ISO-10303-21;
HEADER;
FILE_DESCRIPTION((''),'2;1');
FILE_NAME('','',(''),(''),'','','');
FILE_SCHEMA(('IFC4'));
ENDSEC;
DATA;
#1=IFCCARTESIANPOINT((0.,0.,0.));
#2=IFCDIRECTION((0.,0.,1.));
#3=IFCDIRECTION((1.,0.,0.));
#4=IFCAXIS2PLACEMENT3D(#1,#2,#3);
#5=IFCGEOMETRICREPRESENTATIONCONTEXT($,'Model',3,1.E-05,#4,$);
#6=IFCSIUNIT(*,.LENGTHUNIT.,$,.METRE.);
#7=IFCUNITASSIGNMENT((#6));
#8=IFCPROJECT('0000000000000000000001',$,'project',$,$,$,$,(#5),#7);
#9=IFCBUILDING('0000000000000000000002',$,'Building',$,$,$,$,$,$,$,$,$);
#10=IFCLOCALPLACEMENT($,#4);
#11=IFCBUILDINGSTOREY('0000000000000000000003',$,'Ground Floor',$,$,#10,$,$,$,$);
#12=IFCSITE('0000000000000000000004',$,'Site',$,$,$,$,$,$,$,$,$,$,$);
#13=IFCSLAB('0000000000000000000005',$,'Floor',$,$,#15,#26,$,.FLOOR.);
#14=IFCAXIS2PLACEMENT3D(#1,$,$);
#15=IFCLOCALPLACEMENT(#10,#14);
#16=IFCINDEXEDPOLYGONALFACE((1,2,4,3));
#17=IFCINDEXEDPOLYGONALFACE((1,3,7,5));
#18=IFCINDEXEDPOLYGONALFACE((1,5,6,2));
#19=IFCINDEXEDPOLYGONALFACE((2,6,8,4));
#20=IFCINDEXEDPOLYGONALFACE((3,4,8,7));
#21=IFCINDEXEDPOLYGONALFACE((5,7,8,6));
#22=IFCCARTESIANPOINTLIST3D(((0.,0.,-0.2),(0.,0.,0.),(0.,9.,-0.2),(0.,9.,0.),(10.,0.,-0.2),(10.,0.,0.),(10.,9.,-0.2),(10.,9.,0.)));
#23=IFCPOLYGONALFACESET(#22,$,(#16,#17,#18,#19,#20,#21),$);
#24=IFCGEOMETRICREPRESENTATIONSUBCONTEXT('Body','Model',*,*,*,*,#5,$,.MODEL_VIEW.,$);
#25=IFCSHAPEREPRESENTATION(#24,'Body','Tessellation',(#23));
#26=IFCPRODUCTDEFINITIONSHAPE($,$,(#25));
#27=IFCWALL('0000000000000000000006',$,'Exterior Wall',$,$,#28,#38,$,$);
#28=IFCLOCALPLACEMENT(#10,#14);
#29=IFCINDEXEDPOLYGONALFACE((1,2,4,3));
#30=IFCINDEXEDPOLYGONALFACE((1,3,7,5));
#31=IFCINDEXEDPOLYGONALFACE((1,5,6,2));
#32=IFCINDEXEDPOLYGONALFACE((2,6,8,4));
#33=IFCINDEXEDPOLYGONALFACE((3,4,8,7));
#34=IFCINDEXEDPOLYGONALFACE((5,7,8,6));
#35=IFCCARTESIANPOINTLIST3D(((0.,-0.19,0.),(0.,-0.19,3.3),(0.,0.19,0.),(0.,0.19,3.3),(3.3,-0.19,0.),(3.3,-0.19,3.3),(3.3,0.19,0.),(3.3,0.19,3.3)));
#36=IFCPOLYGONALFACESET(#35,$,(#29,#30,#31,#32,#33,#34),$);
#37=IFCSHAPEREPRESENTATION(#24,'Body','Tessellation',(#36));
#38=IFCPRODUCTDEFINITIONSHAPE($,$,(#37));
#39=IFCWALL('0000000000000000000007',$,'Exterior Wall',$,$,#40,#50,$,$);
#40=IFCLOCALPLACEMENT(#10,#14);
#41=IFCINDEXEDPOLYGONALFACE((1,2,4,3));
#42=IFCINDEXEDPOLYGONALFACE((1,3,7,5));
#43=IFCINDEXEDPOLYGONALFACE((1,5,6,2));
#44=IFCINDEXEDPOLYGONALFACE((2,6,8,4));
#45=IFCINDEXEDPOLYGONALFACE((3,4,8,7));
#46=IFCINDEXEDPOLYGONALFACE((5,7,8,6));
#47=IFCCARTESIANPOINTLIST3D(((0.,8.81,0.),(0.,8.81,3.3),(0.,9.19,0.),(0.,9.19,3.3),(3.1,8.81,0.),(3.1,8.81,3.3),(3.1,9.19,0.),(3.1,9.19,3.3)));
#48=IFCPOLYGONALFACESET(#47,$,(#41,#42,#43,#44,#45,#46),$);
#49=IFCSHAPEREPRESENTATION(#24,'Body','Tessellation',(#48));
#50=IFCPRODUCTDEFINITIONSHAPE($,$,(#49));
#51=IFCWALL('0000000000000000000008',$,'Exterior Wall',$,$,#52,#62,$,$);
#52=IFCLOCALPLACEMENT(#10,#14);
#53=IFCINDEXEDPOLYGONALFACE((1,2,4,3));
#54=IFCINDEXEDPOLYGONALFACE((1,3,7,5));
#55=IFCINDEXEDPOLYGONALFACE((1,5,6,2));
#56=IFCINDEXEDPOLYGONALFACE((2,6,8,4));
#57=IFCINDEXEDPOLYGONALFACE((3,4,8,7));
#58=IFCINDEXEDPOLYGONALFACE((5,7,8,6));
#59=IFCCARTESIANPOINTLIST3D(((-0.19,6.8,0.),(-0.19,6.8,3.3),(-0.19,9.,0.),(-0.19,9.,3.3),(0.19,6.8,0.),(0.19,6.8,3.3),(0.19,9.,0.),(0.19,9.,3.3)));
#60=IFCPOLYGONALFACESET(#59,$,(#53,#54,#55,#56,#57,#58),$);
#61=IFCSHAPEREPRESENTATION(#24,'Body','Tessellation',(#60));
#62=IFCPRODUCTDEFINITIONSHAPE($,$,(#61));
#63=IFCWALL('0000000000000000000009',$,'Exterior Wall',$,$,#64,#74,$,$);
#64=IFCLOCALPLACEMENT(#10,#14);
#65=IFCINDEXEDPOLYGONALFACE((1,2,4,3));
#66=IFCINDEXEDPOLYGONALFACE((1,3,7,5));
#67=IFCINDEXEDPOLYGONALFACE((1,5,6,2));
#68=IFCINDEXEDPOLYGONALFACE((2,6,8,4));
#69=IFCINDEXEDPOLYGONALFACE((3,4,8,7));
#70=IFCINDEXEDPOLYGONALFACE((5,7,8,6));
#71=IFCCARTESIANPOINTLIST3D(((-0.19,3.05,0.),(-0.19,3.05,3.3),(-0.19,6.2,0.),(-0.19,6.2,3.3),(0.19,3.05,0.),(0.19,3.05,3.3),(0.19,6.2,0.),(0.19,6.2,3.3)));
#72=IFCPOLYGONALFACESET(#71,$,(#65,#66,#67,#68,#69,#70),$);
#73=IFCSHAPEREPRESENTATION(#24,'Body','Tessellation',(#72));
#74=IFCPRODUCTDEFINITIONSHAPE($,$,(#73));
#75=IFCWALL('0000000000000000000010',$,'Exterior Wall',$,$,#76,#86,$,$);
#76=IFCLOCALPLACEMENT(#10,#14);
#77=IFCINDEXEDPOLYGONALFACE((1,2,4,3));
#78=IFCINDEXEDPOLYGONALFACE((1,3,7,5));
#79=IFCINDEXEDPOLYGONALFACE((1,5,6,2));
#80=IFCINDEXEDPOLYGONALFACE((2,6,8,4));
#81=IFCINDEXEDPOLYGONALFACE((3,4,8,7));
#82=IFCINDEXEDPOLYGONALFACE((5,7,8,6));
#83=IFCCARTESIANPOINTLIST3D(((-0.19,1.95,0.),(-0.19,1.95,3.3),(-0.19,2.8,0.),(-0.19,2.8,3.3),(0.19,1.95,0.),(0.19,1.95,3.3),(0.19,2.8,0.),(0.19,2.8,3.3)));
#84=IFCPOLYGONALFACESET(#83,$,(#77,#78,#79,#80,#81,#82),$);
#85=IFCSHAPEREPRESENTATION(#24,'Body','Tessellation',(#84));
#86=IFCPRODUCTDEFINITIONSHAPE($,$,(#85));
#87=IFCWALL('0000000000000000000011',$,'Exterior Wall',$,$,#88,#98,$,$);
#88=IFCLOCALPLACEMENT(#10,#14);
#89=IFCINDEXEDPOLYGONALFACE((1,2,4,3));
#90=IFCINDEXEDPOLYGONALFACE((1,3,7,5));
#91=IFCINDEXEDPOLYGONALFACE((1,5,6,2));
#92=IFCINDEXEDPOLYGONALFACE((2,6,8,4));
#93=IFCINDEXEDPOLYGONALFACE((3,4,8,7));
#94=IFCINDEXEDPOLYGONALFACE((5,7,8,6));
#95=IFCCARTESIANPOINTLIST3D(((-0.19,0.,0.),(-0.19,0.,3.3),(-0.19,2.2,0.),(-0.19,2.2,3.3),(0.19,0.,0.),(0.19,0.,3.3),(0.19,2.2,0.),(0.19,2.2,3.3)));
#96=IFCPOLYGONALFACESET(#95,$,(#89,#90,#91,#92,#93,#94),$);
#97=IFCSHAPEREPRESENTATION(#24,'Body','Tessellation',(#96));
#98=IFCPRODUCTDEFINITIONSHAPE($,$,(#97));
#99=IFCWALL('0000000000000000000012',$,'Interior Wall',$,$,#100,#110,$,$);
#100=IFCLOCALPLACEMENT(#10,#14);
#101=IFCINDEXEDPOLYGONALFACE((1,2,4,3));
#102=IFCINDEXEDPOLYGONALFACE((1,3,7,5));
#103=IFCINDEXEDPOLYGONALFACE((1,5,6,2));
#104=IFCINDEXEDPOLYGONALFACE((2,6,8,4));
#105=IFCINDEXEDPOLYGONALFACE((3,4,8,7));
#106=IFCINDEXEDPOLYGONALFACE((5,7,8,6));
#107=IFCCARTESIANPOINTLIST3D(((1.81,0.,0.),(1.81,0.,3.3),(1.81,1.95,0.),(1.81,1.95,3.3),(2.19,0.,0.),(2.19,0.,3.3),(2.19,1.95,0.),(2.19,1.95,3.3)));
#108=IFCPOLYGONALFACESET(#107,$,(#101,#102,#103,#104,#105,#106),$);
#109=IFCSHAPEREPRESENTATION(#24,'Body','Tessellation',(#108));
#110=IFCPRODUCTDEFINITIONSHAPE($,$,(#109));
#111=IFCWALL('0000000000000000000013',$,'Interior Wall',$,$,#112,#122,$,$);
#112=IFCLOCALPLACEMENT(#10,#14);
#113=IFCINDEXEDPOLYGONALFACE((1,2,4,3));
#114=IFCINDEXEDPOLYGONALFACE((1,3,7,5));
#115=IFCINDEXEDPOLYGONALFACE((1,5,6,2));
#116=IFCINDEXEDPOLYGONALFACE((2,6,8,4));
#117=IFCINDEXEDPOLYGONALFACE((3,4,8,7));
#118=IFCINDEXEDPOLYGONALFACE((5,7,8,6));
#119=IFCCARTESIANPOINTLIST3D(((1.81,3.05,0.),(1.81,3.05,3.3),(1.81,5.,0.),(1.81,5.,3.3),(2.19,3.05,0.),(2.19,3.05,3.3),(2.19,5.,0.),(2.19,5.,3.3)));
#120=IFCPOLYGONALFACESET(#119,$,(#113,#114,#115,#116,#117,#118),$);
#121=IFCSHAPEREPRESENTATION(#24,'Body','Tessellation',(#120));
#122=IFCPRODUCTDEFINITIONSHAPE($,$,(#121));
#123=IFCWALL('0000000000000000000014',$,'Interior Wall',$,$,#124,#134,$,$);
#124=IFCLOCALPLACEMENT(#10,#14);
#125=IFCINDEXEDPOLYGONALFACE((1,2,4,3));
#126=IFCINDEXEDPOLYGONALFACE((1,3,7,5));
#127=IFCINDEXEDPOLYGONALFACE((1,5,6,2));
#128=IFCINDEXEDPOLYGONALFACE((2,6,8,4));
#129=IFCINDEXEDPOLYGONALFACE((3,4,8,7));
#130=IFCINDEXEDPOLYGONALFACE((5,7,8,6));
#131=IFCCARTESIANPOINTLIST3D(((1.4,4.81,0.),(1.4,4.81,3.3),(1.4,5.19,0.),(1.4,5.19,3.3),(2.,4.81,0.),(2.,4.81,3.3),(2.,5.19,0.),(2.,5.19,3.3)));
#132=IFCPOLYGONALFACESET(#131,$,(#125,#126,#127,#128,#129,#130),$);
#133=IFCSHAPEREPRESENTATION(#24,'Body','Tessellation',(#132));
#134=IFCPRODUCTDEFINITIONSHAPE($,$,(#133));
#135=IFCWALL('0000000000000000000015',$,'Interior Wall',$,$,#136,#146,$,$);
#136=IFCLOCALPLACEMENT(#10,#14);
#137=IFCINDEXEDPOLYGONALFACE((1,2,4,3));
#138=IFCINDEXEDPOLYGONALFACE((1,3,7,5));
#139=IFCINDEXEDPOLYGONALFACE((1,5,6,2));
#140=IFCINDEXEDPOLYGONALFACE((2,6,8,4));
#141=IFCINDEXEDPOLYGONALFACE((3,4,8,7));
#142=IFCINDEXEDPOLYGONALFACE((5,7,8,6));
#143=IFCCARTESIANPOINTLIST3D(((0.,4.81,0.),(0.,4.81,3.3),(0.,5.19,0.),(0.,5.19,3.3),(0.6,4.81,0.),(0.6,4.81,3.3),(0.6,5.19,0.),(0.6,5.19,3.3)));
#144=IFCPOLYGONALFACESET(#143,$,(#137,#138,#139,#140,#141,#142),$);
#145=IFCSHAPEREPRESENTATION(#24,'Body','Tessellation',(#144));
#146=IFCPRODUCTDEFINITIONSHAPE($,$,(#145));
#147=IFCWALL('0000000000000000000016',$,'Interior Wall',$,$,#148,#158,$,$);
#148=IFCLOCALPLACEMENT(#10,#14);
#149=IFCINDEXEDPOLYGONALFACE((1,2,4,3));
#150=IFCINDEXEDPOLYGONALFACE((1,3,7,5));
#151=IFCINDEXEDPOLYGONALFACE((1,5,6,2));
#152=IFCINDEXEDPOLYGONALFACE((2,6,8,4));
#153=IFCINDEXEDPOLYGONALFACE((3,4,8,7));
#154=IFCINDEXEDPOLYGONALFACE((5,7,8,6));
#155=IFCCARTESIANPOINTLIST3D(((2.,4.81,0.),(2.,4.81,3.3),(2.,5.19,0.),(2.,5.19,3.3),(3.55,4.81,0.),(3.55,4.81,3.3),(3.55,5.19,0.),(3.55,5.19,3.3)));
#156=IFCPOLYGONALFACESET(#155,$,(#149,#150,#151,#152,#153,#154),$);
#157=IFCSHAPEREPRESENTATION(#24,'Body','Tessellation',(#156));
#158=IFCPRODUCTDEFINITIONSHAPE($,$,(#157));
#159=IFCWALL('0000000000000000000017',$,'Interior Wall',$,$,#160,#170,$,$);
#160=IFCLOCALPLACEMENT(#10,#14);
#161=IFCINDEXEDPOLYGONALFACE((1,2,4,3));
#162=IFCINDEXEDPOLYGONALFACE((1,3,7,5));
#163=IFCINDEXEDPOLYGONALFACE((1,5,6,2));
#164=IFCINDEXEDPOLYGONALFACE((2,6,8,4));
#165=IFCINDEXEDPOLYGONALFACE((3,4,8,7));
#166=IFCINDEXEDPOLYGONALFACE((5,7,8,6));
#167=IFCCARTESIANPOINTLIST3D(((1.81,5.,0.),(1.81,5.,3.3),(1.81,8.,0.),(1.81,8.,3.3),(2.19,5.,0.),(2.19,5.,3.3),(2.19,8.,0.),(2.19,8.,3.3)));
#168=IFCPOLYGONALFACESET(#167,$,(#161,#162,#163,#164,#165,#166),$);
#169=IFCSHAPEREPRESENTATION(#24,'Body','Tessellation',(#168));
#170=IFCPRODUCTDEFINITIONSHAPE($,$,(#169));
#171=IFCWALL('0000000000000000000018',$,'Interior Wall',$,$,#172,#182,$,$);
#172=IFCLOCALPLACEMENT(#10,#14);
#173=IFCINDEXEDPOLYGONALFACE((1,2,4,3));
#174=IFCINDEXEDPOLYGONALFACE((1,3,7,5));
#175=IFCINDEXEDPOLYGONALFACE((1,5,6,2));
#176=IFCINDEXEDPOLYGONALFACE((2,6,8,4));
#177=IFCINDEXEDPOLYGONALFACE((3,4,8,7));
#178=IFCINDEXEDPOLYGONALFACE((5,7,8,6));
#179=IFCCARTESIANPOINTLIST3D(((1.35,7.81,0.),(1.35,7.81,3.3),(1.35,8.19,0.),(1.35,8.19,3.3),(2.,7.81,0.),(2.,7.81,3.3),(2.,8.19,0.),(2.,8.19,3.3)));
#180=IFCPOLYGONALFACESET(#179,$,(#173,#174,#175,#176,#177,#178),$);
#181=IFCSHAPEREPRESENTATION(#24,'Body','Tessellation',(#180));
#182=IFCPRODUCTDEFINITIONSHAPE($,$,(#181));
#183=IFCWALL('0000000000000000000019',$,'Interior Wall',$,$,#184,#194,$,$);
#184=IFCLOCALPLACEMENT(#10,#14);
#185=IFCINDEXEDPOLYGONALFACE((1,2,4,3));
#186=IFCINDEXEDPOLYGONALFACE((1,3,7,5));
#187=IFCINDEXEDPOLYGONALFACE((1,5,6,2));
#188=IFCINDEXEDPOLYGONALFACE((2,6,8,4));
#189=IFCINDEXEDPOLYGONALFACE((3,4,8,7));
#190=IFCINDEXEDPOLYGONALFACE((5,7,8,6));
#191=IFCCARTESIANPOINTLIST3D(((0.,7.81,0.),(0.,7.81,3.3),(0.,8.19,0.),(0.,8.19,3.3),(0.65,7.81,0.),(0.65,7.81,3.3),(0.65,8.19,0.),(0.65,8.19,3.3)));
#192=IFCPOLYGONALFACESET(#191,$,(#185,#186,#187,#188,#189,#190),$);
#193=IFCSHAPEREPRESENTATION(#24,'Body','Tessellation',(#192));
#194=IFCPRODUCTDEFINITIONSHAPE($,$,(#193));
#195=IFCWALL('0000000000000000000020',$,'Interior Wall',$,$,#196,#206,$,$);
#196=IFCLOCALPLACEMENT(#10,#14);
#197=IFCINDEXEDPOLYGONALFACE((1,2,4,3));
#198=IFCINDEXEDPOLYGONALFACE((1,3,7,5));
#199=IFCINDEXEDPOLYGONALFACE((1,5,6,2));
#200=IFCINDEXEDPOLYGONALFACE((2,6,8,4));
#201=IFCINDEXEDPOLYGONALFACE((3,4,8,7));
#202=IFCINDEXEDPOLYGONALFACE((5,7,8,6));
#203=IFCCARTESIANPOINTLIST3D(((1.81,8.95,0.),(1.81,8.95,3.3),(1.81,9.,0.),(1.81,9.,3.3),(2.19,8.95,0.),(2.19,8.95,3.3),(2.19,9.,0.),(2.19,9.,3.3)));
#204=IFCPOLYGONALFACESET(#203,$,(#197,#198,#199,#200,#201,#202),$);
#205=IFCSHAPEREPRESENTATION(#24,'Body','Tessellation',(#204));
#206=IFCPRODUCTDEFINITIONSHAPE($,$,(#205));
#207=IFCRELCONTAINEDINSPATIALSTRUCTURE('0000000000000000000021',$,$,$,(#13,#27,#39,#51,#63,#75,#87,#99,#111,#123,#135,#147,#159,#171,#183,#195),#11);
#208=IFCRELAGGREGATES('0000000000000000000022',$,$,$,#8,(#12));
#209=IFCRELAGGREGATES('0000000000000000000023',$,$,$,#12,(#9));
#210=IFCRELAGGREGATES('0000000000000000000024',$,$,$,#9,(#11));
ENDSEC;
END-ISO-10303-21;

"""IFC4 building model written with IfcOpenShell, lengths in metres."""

from ifc_helpers import new_model, si_unit, frame, origin_with_axes, place, context, subcontext, project, spatial, indexed_curve, outline, extrude, element, save


model = new_model("IFC4")

# Units and contexts
model_context = context("Model", 3, precision=1e-05, world=origin_with_axes())
body_context = subcontext(model_context, "Body", "Model", "MODEL_VIEW")
ifc_project = project(units=[si_unit("LENGTHUNIT", "METRE")], contexts=[model_context])

# Site, building, storey
site = spatial("IfcSite", under=ifc_project, Name="Site")
building = spatial("IfcBuilding", under=site, Name="Building")
storey_placement = place(None, origin_with_axes())
storey = spatial("IfcBuildingStorey", under=building, at=storey_placement, Name="Ground Floor")

# Slab
slab_placement = place(storey_placement, frame((0.0, 0.0, -0.2), z_axis=(0.0, 0.0, 1.0), x_axis=(1.0, 0.0, 0.0)))
element("IfcSlab", 1, at=slab_placement, inside=storey, Name="Floor", PredefinedType="FLOOR", context=body_context, shape_type="SweptSolid", body=[
    extrude(outline(indexed_curve([(0.0, 0.0), (10.0, 0.0), (10.0, 9.0), (0.0, 9.0)])), None, (0.0, 0.0, 1.0), 0.2),
])

# Walls
wall_1_placement = place(storey_placement, origin_with_axes())
element("IfcWall", 2, at=wall_1_placement, inside=storey, Name="Exterior Wall", context=body_context, shape_type="SweptSolid", body=[
    extrude(outline(indexed_curve([(0.0, 0.0), (0.0, 0.38), (3.3, 0.38), (3.3, 0.0), (0.0, 0.0)], self_intersect=False)), frame((0.0, -0.19, 0.0), z_axis=(0.0, 0.0, 1.0), x_axis=(1.0, 0.0, 0.0)), (0.0, 0.0, 1.0), 3.3),
])
wall_2_placement = place(storey_placement, frame((3.1, 9.0, 0.0), z_axis=(0.0, 0.0, 1.0), x_axis=(-1.0, 0.0, 0.0)))
element("IfcWall", 3, at=wall_2_placement, inside=storey, Name="Exterior Wall", context=body_context, shape_type="SweptSolid", body=[
    extrude(outline(indexed_curve([(0.0, 0.0), (0.0, 0.38), (3.1, 0.38), (3.1, 0.0), (0.0, 0.0)], self_intersect=False)), frame((0.0, -0.19, 0.0), z_axis=(0.0, 0.0, 1.0), x_axis=(1.0, 0.0, 0.0)), (0.0, 0.0, 1.0), 3.3),
])
wall_3_placement = place(storey_placement, frame((0.0, 9.0, 0.0), z_axis=(0.0, 0.0, 1.0), x_axis=(0.0, -1.0, 0.0)))
element("IfcWall", 4, at=wall_3_placement, inside=storey, Name="Exterior Wall", context=body_context, shape_type="SweptSolid", body=[
    extrude(outline(indexed_curve([(0.0, 0.0), (0.0, 0.38), (2.2, 0.38), (2.2, 0.0), (0.0, 0.0)], self_intersect=False)), frame((0.0, -0.19, 0.0), z_axis=(0.0, 0.0, 1.0), x_axis=(1.0, 0.0, 0.0)), (0.0, 0.0, 1.0), 3.3),
])
wall_4_placement = place(storey_placement, frame((0.0, 6.2, 0.0), z_axis=(0.0, 0.0, 1.0), x_axis=(0.0, -1.0, 0.0)))
element("IfcWall", 5, at=wall_4_placement, inside=storey, Name="Exterior Wall", context=body_context, shape_type="SweptSolid", body=[
    extrude(outline(indexed_curve([(0.0, 0.0), (0.0, 0.38), (3.15, 0.38), (3.15, 0.0), (0.0, 0.0)], self_intersect=False)), frame((0.0, -0.19, 0.0), z_axis=(0.0, 0.0, 1.0), x_axis=(1.0, 0.0, 0.0)), (0.0, 0.0, 1.0), 3.3),
])
wall_5_placement = place(storey_placement, frame((0.0, 1.95, 0.0), z_axis=(0.0, 0.0, 1.0), x_axis=(0.0, 1.0, 0.0)))
element("IfcWall", 6, at=wall_5_placement, inside=storey, Name="Exterior Wall", context=body_context, shape_type="SweptSolid", body=[
    extrude(outline(indexed_curve([(0.0, 0.0), (0.0, 0.38), (0.85, 0.38), (0.85, 0.0), (0.0, 0.0)], self_intersect=False)), frame((0.0, -0.19, 0.0), z_axis=(0.0, 0.0, 1.0), x_axis=(1.0, 0.0, 0.0)), (0.0, 0.0, 1.0), 3.3),
])
wall_6_placement = place(storey_placement, frame((0.0, 2.2, 0.0), z_axis=(0.0, 0.0, 1.0), x_axis=(0.0, -1.0, 0.0)))
element("IfcWall", 7, at=wall_6_placement, inside=storey, Name="Exterior Wall", context=body_context, shape_type="SweptSolid", body=[
    extrude(outline(indexed_curve([(0.0, 0.0), (0.0, 0.38), (2.2, 0.38), (2.2, 0.0), (0.0, 0.0)], self_intersect=False)), frame((0.0, -0.19, 0.0), z_axis=(0.0, 0.0, 1.0), x_axis=(1.0, 0.0, 0.0)), (0.0, 0.0, 1.0), 3.3),
])
wall_7_placement = place(storey_placement, frame((2.0, 0.0, 0.0), z_axis=(0.0, 0.0, 1.0), x_axis=(0.0, 1.0, 0.0)))
element("IfcWall", 8, at=wall_7_placement, inside=storey, Name="Interior Wall", context=body_context, shape_type="SweptSolid", body=[
    extrude(outline(indexed_curve([(0.0, 0.0), (0.0, 0.38), (1.95, 0.38), (1.95, 0.0), (0.0, 0.0)], self_intersect=False)), frame((0.0, -0.19, 0.0), z_axis=(0.0, 0.0, 1.0), x_axis=(1.0, 0.0, 0.0)), (0.0, 0.0, 1.0), 3.3),
])
wall_8_placement = place(storey_placement, frame((2.0, 3.05, 0.0), z_axis=(0.0, 0.0, 1.0), x_axis=(0.0, 1.0, 0.0)))
element("IfcWall", 9, at=wall_8_placement, inside=storey, Name="Interior Wall", context=body_context, shape_type="SweptSolid", body=[
    extrude(outline(indexed_curve([(0.0, 0.0), (0.0, 0.38), (1.95, 0.38), (1.95, 0.0), (0.0, 0.0)], self_intersect=False)), frame((0.0, -0.19, 0.0), z_axis=(0.0, 0.0, 1.0), x_axis=(1.0, 0.0, 0.0)), (0.0, 0.0, 1.0), 3.3),
])
for number, where, z_axis, x_axis, name in (
    (10, (2.0, 5.0, 0.0), (0.0, 0.0, 1.0), (-1.0, 0.0, 0.0), "Interior Wall"),
    (11, (0.6, 5.0, 0.0), (0.0, 0.0, 1.0), (-1.0, 0.0, 0.0), "Interior Wall"),
):
    element("IfcWall", number, at=place(storey_placement, frame(where, z_axis=z_axis, x_axis=x_axis)), inside=storey, Name=name, context=body_context, shape_type="SweptSolid", body=[
        extrude(outline(indexed_curve([(0.0, 0.0), (0.0, 0.38), (0.6, 0.38), (0.6, 0.0), (0.0, 0.0)], self_intersect=False)), frame((0.0, -0.19, 0.0), z_axis=(0.0, 0.0, 1.0), x_axis=(1.0, 0.0, 0.0)), (0.0, 0.0, 1.0), 3.3),
    ])
wall_9_placement = place(storey_placement, frame((3.55, 5.0, 0.0), z_axis=(0.0, 0.0, 1.0), x_axis=(-1.0, 0.0, 0.0)))
element("IfcWall", 12, at=wall_9_placement, inside=storey, Name="Interior Wall", context=body_context, shape_type="SweptSolid", body=[
    extrude(outline(indexed_curve([(0.0, 0.0), (0.0, 0.38), (1.55, 0.38), (1.55, 0.0), (0.0, 0.0)], self_intersect=False)), frame((0.0, -0.19, 0.0), z_axis=(0.0, 0.0, 1.0), x_axis=(1.0, 0.0, 0.0)), (0.0, 0.0, 1.0), 3.3),
])
wall_10_placement = place(storey_placement, frame((2.0, 5.0, 0.0), z_axis=(0.0, 0.0, 1.0), x_axis=(0.0, 1.0, 0.0)))
element("IfcWall", 13, at=wall_10_placement, inside=storey, Name="Interior Wall", context=body_context, shape_type="SweptSolid", body=[
    extrude(outline(indexed_curve([(0.0, 0.0), (0.0, 0.38), (3.0, 0.38), (3.0, 0.0), (0.0, 0.0)], self_intersect=False)), frame((0.0, -0.19, 0.0), z_axis=(0.0, 0.0, 1.0), x_axis=(1.0, 0.0, 0.0)), (0.0, 0.0, 1.0), 3.3),
])
for number, where, z_axis, x_axis, name in (
    (14, (2.0, 8.0, 0.0), (0.0, 0.0, 1.0), (-1.0, 0.0, 0.0), "Interior Wall"),
    (15, (0.65, 8.0, 0.0), (0.0, 0.0, 1.0), (-1.0, 0.0, 0.0), "Interior Wall"),
):
    element("IfcWall", number, at=place(storey_placement, frame(where, z_axis=z_axis, x_axis=x_axis)), inside=storey, Name=name, context=body_context, shape_type="SweptSolid", body=[
        extrude(outline(indexed_curve([(0.0, 0.0), (0.0, 0.38), (0.65, 0.38), (0.65, 0.0), (0.0, 0.0)], self_intersect=False)), frame((0.0, -0.19, 0.0), z_axis=(0.0, 0.0, 1.0), x_axis=(1.0, 0.0, 0.0)), (0.0, 0.0, 1.0), 3.3),
    ])
for number, where, z_axis, x_axis, name in (
    (16, (2.0, 9.0, 0.0), (0.0, 0.0, 1.0), (0.0, -1.0, 0.0), "Interior Wall"),
):
    element("IfcWall", number, at=place(storey_placement, frame(where, z_axis=z_axis, x_axis=x_axis)), inside=storey, Name=name, context=body_context, shape_type="SweptSolid", body=[
        extrude(outline(indexed_curve([(0.0, 0.0), (0.0, 0.38), (0.05, 0.38), (0.05, 0.0), (0.0, 0.0)], self_intersect=False)), frame((0.0, -0.19, 0.0), z_axis=(0.0, 0.0, 1.0), x_axis=(1.0, 0.0, 0.0)), (0.0, 0.0, 1.0), 3.3),
    ])

save(model, "model.ifc")
